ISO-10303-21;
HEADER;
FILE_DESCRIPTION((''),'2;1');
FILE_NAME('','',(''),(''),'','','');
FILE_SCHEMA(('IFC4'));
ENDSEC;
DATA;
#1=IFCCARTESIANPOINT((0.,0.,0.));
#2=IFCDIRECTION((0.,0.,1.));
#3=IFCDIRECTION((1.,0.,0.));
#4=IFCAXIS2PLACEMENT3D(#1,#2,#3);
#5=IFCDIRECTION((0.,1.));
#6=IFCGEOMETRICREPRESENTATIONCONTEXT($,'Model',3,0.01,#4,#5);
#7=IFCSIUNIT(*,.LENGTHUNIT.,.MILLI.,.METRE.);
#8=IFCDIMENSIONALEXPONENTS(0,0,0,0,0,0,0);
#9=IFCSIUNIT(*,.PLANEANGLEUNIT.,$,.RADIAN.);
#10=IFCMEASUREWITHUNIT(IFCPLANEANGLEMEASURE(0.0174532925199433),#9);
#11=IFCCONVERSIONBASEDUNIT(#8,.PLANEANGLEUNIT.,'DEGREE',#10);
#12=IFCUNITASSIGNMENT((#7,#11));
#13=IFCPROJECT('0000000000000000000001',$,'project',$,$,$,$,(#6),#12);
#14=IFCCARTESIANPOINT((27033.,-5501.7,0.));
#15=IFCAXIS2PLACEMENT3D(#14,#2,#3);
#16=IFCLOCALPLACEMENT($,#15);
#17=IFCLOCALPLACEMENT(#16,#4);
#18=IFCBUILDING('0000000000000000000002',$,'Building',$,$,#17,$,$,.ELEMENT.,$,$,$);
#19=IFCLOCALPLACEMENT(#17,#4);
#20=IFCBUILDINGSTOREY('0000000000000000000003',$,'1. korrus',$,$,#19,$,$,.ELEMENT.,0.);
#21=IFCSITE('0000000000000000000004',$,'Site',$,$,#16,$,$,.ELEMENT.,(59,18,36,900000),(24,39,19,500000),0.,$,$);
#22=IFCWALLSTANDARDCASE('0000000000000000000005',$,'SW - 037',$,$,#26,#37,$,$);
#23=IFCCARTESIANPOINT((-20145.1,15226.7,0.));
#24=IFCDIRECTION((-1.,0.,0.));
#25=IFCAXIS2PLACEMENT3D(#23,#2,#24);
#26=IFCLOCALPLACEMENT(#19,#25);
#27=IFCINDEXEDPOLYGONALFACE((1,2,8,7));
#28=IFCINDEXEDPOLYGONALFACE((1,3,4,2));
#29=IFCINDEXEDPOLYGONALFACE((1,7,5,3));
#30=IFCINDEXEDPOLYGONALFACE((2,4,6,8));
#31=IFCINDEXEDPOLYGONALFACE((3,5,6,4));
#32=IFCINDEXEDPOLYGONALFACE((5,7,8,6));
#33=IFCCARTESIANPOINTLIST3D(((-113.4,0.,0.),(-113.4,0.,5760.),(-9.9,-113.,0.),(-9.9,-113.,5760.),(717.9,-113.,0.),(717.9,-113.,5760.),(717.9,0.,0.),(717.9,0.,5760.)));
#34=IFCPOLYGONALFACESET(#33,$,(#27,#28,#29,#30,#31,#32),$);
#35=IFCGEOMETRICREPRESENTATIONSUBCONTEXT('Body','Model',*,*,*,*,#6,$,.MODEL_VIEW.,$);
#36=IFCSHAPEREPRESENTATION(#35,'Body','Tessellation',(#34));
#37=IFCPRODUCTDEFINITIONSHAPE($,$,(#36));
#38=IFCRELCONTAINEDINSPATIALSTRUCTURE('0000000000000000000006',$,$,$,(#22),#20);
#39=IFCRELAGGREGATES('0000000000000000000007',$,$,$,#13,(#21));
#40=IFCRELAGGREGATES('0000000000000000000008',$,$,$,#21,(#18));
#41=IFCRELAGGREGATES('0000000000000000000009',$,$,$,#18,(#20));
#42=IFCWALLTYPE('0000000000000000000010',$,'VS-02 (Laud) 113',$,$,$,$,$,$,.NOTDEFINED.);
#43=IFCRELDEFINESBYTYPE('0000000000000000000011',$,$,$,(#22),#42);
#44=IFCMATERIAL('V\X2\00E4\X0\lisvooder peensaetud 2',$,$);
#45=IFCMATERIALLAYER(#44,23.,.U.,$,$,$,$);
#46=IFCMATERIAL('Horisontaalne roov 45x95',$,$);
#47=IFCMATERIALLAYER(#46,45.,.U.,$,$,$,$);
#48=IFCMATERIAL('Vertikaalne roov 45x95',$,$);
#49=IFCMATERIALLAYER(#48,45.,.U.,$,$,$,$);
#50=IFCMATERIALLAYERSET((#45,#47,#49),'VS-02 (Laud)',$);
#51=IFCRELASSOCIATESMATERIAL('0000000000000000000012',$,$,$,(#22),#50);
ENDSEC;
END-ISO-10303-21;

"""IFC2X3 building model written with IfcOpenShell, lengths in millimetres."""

from ifc_helpers import new_model, entity, si_unit, converted_unit, direction, frame, origin_with_axes, place, context, subcontext, project, spatial, polyline, outline, extrude, material, layer, layer_set, layer_usage, type_object, element, save


model = new_model("IFC2X3")

# Units and contexts
model_context = context("Model", 3, precision=0.01, world=origin_with_axes(), true_north=direction((0.0, 1.0)))
body_context = subcontext(model_context, "Body", "Model", "MODEL_VIEW")
ifc_project = project(units=[si_unit("LENGTHUNIT", "METRE", prefix="MILLI"), converted_unit("PLANEANGLEUNIT", "DEGREE", entity("IfcPlaneAngleMeasure", 0.0174532925199433), si_unit("PLANEANGLEUNIT", "RADIAN"), dimensions=[0, 0, 0, 0, 0, 0, 0])], contexts=[model_context])

# Site, building, storey
site_placement = place(None, frame((27033.0, -5501.7, 0.0), z_axis=(0.0, 0.0, 1.0), x_axis=(1.0, 0.0, 0.0)))
site = spatial("IfcSite", under=ifc_project, at=site_placement, Name="Site", CompositionType="ELEMENT", RefLatitude=(59, 18, 36, 900000), RefLongitude=(24, 39, 19, 500000), RefElevation=0.0)
building_placement = place(site_placement, origin_with_axes())
building = spatial("IfcBuilding", under=site, at=building_placement, Name="Building", CompositionType="ELEMENT")
storey_placement = place(building_placement, origin_with_axes())
storey = spatial("IfcBuildingStorey", under=building, at=storey_placement, Name="1. korrus", CompositionType="ELEMENT", Elevation=0.0)

# Wall
ifc_material_1 = material(Name="Välisvooder peensaetud 2")
ifc_layer_1 = layer(ifc_material_1, 23.0, ventilated="UNKNOWN")
ifc_material_2 = material(Name="Horisontaalne roov 45x95")
ifc_layer_2 = layer(ifc_material_2, 45.0, ventilated="UNKNOWN")
ifc_material_3 = material(Name="Vertikaalne roov 45x95")
ifc_layer_3 = layer(ifc_material_3, 45.0, ventilated="UNKNOWN")
ifc_layer_set_1 = layer_set([ifc_layer_1, ifc_layer_2, ifc_layer_3], Name="VS-02 (Laud)")
wall_type_1 = type_object("IfcWallType", Name="VS-02 (Laud) 113", PredefinedType="NOTDEFINED")
ifc_layer_usage_1 = layer_usage(ifc_layer_set_1, "AXIS2", "POSITIVE", -113.0)
wall_1_placement = place(storey_placement, frame((-20145.1, 15226.7, 0.0), z_axis=(0.0, 0.0, 1.0), x_axis=(-1.0, 0.0, 0.0)))
element("IfcWallStandardCase", 1, at=wall_1_placement, inside=storey, type_object=wall_type_1, material=ifc_layer_usage_1, Name="SW - 037", context=body_context, shape_type="SweptSolid", body=[
    extrude(outline(polyline([(-9.9, -113.0), (717.9, -113.0), (717.9, 0.0), (-113.4, 0.0), (-9.9, -113.0)])), origin_with_axes(), (0.0, 0.0, 1.0), 5760.0),
])

save(model, "model.ifc")
